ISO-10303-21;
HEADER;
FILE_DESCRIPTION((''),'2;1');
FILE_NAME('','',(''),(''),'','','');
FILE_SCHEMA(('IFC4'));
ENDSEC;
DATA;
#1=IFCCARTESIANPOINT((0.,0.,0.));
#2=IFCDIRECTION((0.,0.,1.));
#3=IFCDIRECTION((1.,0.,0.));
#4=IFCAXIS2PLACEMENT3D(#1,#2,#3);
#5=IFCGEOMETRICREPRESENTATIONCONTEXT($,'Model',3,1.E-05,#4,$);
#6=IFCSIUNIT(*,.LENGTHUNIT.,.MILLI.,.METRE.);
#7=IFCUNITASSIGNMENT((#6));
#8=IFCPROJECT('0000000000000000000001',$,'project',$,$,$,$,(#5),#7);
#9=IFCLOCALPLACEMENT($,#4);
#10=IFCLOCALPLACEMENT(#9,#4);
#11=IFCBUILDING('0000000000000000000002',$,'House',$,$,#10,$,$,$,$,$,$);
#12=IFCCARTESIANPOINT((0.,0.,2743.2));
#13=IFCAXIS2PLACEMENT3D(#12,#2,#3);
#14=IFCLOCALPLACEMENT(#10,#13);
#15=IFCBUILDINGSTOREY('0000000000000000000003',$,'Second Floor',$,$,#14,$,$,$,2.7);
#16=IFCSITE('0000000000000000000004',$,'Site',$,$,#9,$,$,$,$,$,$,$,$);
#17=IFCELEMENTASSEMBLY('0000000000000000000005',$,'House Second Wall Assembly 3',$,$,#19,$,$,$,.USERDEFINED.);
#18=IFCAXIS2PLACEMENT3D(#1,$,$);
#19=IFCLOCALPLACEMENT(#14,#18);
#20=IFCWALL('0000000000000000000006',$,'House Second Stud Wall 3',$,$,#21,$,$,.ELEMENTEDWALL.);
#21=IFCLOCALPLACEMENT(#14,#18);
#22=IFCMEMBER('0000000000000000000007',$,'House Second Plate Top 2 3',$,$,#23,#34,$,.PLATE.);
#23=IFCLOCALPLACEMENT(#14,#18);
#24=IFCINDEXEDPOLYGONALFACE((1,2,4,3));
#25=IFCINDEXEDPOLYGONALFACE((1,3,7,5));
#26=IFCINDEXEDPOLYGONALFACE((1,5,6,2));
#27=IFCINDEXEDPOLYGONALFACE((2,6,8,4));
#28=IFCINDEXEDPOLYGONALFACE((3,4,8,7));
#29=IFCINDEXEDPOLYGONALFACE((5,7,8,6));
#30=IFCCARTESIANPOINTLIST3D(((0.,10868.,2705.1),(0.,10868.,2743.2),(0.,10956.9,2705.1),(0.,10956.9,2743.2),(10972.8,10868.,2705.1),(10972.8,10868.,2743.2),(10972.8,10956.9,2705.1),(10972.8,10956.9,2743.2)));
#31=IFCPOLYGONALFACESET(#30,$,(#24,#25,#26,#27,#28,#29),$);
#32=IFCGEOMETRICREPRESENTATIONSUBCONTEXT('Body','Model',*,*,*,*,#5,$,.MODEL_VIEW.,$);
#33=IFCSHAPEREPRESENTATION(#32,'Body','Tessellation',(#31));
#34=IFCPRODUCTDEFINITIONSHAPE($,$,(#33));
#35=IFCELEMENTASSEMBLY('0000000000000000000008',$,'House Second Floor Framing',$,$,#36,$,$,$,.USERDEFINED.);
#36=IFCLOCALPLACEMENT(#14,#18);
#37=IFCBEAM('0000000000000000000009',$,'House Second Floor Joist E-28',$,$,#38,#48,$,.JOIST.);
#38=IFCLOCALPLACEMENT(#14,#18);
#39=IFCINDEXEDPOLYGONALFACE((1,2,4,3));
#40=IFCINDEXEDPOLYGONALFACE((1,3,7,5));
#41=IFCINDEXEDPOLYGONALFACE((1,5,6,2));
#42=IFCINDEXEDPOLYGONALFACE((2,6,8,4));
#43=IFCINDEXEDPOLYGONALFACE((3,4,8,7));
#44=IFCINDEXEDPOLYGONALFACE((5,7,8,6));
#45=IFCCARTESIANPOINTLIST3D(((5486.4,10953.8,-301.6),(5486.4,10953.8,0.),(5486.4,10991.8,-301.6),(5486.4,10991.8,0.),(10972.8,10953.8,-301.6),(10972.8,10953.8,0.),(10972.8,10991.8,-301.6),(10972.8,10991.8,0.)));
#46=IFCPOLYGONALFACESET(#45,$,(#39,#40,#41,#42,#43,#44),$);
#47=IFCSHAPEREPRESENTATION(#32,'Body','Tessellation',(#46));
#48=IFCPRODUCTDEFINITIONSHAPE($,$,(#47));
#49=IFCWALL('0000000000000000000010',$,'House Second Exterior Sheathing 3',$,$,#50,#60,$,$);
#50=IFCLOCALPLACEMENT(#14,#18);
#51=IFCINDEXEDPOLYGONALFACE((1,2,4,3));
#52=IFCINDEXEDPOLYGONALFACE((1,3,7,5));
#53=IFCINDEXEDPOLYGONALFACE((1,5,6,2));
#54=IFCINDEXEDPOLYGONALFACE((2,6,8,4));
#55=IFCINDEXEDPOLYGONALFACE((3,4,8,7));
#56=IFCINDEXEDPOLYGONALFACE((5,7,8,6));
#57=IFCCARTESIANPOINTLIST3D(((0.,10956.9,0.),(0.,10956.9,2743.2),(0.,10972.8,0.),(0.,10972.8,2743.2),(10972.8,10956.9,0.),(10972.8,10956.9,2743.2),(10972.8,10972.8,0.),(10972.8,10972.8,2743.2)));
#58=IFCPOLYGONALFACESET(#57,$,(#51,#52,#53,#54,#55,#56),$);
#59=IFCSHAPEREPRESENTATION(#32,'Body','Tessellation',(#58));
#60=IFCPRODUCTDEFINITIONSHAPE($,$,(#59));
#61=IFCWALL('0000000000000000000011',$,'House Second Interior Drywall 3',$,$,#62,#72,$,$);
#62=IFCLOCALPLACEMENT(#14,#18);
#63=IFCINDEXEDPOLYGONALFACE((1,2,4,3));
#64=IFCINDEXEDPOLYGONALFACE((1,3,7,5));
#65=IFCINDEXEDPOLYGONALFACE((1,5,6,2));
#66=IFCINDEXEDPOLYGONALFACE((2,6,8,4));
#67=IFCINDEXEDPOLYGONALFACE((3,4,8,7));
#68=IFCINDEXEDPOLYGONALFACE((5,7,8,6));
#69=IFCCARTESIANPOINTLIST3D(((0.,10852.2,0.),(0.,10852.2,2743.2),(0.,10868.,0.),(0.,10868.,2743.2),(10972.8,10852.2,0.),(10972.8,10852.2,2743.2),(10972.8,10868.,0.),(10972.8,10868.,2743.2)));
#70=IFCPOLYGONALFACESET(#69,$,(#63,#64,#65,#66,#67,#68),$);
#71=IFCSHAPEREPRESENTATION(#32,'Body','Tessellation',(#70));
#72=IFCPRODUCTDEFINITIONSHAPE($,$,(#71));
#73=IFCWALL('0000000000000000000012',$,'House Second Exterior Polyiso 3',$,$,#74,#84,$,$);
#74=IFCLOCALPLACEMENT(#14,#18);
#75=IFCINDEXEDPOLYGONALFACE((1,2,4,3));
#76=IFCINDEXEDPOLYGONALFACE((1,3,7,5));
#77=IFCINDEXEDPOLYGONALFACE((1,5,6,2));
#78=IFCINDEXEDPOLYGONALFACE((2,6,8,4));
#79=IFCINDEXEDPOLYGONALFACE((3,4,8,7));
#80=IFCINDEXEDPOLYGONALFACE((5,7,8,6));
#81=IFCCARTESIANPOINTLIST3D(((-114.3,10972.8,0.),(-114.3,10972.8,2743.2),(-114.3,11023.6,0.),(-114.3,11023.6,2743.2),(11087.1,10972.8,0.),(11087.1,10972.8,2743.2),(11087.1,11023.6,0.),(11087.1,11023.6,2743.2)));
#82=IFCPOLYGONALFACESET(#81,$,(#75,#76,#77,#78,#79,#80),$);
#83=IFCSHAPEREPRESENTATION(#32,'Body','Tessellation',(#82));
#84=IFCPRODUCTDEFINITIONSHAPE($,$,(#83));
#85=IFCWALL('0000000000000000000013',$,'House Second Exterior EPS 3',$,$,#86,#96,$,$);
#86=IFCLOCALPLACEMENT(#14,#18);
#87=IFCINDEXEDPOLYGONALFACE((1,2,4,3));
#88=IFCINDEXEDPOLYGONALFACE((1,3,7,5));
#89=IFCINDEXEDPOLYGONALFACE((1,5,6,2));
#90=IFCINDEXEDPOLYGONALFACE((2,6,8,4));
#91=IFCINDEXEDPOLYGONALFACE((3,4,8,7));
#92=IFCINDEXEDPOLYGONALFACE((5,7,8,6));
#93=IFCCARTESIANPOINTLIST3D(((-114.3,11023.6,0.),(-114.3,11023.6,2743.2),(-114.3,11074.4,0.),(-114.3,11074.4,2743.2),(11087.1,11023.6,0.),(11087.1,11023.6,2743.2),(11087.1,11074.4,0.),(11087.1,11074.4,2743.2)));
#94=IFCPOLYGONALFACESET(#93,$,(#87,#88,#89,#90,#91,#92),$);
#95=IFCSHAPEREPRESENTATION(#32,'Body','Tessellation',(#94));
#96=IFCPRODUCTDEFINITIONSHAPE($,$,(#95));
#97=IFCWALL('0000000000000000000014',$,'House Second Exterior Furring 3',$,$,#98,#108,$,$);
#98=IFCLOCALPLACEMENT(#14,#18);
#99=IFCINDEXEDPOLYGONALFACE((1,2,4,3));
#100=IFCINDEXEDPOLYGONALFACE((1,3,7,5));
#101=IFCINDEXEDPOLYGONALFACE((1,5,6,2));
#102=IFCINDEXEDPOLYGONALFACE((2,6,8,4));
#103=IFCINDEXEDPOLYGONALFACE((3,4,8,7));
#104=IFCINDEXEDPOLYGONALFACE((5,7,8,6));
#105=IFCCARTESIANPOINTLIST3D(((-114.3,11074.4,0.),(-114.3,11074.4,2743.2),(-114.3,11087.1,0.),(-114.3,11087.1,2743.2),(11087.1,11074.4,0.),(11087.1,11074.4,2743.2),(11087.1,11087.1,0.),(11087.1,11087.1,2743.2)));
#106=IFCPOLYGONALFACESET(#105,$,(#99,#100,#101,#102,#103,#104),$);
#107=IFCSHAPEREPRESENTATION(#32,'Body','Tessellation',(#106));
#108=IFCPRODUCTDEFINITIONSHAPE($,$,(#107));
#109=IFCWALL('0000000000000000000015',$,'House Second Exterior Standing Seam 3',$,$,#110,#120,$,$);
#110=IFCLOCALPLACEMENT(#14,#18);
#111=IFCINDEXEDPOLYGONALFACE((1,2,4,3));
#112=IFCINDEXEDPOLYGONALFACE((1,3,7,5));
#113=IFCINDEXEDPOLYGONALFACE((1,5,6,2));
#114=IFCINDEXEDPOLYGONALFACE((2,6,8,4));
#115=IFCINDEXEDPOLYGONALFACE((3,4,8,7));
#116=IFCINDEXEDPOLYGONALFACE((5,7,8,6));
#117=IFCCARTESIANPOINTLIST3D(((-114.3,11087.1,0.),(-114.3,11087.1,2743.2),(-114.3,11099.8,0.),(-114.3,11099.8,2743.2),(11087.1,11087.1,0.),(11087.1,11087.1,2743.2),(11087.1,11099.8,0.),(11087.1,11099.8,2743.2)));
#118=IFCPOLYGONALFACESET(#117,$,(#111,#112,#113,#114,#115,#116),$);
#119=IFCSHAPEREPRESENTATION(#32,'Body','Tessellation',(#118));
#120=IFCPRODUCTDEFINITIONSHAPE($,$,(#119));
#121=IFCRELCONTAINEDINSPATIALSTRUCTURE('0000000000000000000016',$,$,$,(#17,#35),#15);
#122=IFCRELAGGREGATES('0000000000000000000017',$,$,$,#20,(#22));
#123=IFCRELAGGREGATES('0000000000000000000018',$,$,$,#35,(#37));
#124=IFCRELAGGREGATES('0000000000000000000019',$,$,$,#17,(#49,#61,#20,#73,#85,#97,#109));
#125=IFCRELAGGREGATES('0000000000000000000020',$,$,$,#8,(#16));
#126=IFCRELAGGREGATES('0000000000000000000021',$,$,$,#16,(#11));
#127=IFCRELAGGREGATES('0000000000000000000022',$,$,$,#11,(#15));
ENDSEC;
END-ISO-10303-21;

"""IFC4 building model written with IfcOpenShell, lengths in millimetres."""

from ifc_helpers import new_model, si_unit, frame, origin_with_axes, origin_2d, place, context, subcontext, project, spatial, indexed_curve, rectangle, outline, extrude, element, aggregate, save


model = new_model("IFC4")

# Units and contexts
model_context = context("Model", 3, precision=1e-05, world=origin_with_axes())
body_context = subcontext(model_context, "Body", "Model", "MODEL_VIEW")
ifc_project = project(units=[si_unit("LENGTHUNIT", "METRE", prefix="MILLI")], contexts=[model_context])

# Site, building, storey
site_placement = place(None, origin_with_axes())
site = spatial("IfcSite", under=ifc_project, at=site_placement, Name="Site")
building_placement = place(site_placement, origin_with_axes())
building = spatial("IfcBuilding", under=site, at=building_placement, Name="House")
storey_placement = place(building_placement, frame((0.0, 0.0, 2743.2), z_axis=(0.0, 0.0, 1.0), x_axis=(1.0, 0.0, 0.0)))
storey = spatial("IfcBuildingStorey", under=building, at=storey_placement, Name="Second Floor", Elevation=2.7)

# Element assembly, wall, member
assembly_1_placement = place(storey_placement, frame((0.0, 0.0, -2743.2), z_axis=(0.0, 0.0, 1.0), x_axis=(1.0, 0.0, 0.0)))
assembly_1 = element("IfcElementAssembly", 1, at=assembly_1_placement, inside=storey, Name="House Second Wall Assembly 3", PredefinedType="USERDEFINED")
wall_1_placement = place(assembly_1_placement, frame((10972.8, 10972.8, 2743.2), z_axis=(0.0, 0.0, 1.0), x_axis=(-1.0, 0.0, 0.0)))
wall_1 = element("IfcWall", 2, at=wall_1_placement, Name="House Second Stud Wall 3", PredefinedType="ELEMENTEDWALL")
member_1_placement = place(wall_1_placement, frame((0.0, 60.3, 2724.2), z_axis=(1.0, 0.0, 0.0), x_axis=(0.0, 0.0, 1.0)))
member_1 = element("IfcMember", 3, at=member_1_placement, Name="House Second Plate Top 2 3", PredefinedType="PLATE", context=body_context, shape_type="SweptSolid", body=[
    extrude(rectangle(XDim=38.1, YDim=88.9, at=origin_2d()), origin_with_axes(), (0.0, 0.0, 1.0), 10972.8),
])
aggregate(wall_1, [member_1])

# Element assembly, beam
assembly_2_placement = place(storey_placement, frame((0.0, 0.0, -2743.2), z_axis=(0.0, 0.0, 1.0), x_axis=(1.0, 0.0, 0.0)))
assembly_2 = element("IfcElementAssembly", 4, at=assembly_2_placement, inside=storey, Name="House Second Floor Framing", PredefinedType="USERDEFINED")
beam_placement = place(assembly_2_placement, frame((5486.4, 10972.8, 2592.4), z_axis=(1.0, 0.0, 0.0), x_axis=(0.0, 1.0, 0.0)))
beam = element("IfcBeam", 5, at=beam_placement, Name="House Second Floor Joist E-28", PredefinedType="JOIST", context=body_context, shape_type="SweptSolid", body=[
    extrude(rectangle(XDim=38.1, YDim=301.6, at=origin_2d()), origin_with_axes(), (0.0, 0.0, 1.0), 5486.4),
])
aggregate(assembly_2, [beam])

# Walls
wall_2_placement = place(assembly_1_placement, frame((10972.8, 10972.8, 2743.2), z_axis=(0.0, 0.0, 1.0), x_axis=(-1.0, 0.0, 0.0)))
wall_2 = element("IfcWall", 6, at=wall_2_placement, Name="House Second Exterior Sheathing 3", context=body_context, shape_type="SweptSolid", body=[
    extrude(outline(indexed_curve([(0.0, 0.0), (0.0, 15.9), (10972.8, 15.9), (10972.8, 0.0), (0.0, 0.0)], self_intersect=False)), origin_with_axes(), (0.0, 0.0, 1.0), 2743.2),
])
wall_3_placement = place(assembly_1_placement, frame((10972.8, 10972.8, 2743.2), z_axis=(0.0, 0.0, 1.0), x_axis=(-1.0, 0.0, 0.0)))
wall_3 = element("IfcWall", 7, at=wall_3_placement, Name="House Second Interior Drywall 3", context=body_context, shape_type="SweptSolid", body=[
    extrude(outline(indexed_curve([(0.0, 0.0), (0.0, 15.9), (10972.8, 15.9), (10972.8, 0.0), (0.0, 0.0)], self_intersect=False)), frame((0.0, 104.8, 0.0), z_axis=(0.0, 0.0, 1.0), x_axis=(1.0, 0.0, 0.0)), (0.0, 0.0, 1.0), 2743.2),
])
wall_4_placement = place(assembly_1_placement, frame((11087.1, 10972.8, 2743.2), z_axis=(0.0, 0.0, 1.0), x_axis=(-1.0, 0.0, 0.0)))
wall_4 = element("IfcWall", 8, at=wall_4_placement, Name="House Second Exterior Polyiso 3", context=body_context, shape_type="SweptSolid", body=[
    extrude(outline(indexed_curve([(0.0, 0.0), (0.0, -50.8), (11201.4, -50.8), (11201.4, 0.0), (0.0, 0.0)], self_intersect=False)), origin_with_axes(), (0.0, 0.0, 1.0), 2743.2),
])
wall_5_placement = place(assembly_1_placement, frame((11087.1, 10972.8, 2743.2), z_axis=(0.0, 0.0, 1.0), x_axis=(-1.0, 0.0, 0.0)))
wall_5 = element("IfcWall", 9, at=wall_5_placement, Name="House Second Exterior EPS 3", context=body_context, shape_type="SweptSolid", body=[
    extrude(outline(indexed_curve([(0.0, 0.0), (0.0, -50.8), (11201.4, -50.8), (11201.4, 0.0), (0.0, 0.0)], self_intersect=False)), frame((0.0, -50.8, 0.0), z_axis=(0.0, 0.0, 1.0), x_axis=(1.0, 0.0, 0.0)), (0.0, 0.0, 1.0), 2743.2),
])
wall_6_placement = place(assembly_1_placement, frame((11087.1, 10972.8, 2743.2), z_axis=(0.0, 0.0, 1.0), x_axis=(-1.0, 0.0, 0.0)))
wall_6 = element("IfcWall", 10, at=wall_6_placement, Name="House Second Exterior Furring 3", context=body_context, shape_type="SweptSolid", body=[
    extrude(outline(indexed_curve([(0.0, 0.0), (0.0, -12.7), (11201.4, -12.7), (11201.4, 0.0), (0.0, 0.0)], self_intersect=False)), frame((0.0, -101.6, 0.0), z_axis=(0.0, 0.0, 1.0), x_axis=(1.0, 0.0, 0.0)), (0.0, 0.0, 1.0), 2743.2),
])
wall_7_placement = place(assembly_1_placement, frame((11087.1, 10972.8, 2743.2), z_axis=(0.0, 0.0, 1.0), x_axis=(-1.0, 0.0, 0.0)))
wall_7 = element("IfcWall", 11, at=wall_7_placement, Name="House Second Exterior Standing Seam 3", context=body_context, shape_type="SweptSolid", body=[
    extrude(outline(indexed_curve([(0.0, 0.0), (0.0, -12.7), (11201.4, -12.7), (11201.4, 0.0), (0.0, 0.0)], self_intersect=False)), frame((0.0, -114.3, 0.0), z_axis=(0.0, 0.0, 1.0), x_axis=(1.0, 0.0, 0.0)), (0.0, 0.0, 1.0), 2743.2),
])
aggregate(assembly_1, [wall_2, wall_3, wall_1, wall_4, wall_5, wall_6, wall_7])

save(model, "model.ifc")
